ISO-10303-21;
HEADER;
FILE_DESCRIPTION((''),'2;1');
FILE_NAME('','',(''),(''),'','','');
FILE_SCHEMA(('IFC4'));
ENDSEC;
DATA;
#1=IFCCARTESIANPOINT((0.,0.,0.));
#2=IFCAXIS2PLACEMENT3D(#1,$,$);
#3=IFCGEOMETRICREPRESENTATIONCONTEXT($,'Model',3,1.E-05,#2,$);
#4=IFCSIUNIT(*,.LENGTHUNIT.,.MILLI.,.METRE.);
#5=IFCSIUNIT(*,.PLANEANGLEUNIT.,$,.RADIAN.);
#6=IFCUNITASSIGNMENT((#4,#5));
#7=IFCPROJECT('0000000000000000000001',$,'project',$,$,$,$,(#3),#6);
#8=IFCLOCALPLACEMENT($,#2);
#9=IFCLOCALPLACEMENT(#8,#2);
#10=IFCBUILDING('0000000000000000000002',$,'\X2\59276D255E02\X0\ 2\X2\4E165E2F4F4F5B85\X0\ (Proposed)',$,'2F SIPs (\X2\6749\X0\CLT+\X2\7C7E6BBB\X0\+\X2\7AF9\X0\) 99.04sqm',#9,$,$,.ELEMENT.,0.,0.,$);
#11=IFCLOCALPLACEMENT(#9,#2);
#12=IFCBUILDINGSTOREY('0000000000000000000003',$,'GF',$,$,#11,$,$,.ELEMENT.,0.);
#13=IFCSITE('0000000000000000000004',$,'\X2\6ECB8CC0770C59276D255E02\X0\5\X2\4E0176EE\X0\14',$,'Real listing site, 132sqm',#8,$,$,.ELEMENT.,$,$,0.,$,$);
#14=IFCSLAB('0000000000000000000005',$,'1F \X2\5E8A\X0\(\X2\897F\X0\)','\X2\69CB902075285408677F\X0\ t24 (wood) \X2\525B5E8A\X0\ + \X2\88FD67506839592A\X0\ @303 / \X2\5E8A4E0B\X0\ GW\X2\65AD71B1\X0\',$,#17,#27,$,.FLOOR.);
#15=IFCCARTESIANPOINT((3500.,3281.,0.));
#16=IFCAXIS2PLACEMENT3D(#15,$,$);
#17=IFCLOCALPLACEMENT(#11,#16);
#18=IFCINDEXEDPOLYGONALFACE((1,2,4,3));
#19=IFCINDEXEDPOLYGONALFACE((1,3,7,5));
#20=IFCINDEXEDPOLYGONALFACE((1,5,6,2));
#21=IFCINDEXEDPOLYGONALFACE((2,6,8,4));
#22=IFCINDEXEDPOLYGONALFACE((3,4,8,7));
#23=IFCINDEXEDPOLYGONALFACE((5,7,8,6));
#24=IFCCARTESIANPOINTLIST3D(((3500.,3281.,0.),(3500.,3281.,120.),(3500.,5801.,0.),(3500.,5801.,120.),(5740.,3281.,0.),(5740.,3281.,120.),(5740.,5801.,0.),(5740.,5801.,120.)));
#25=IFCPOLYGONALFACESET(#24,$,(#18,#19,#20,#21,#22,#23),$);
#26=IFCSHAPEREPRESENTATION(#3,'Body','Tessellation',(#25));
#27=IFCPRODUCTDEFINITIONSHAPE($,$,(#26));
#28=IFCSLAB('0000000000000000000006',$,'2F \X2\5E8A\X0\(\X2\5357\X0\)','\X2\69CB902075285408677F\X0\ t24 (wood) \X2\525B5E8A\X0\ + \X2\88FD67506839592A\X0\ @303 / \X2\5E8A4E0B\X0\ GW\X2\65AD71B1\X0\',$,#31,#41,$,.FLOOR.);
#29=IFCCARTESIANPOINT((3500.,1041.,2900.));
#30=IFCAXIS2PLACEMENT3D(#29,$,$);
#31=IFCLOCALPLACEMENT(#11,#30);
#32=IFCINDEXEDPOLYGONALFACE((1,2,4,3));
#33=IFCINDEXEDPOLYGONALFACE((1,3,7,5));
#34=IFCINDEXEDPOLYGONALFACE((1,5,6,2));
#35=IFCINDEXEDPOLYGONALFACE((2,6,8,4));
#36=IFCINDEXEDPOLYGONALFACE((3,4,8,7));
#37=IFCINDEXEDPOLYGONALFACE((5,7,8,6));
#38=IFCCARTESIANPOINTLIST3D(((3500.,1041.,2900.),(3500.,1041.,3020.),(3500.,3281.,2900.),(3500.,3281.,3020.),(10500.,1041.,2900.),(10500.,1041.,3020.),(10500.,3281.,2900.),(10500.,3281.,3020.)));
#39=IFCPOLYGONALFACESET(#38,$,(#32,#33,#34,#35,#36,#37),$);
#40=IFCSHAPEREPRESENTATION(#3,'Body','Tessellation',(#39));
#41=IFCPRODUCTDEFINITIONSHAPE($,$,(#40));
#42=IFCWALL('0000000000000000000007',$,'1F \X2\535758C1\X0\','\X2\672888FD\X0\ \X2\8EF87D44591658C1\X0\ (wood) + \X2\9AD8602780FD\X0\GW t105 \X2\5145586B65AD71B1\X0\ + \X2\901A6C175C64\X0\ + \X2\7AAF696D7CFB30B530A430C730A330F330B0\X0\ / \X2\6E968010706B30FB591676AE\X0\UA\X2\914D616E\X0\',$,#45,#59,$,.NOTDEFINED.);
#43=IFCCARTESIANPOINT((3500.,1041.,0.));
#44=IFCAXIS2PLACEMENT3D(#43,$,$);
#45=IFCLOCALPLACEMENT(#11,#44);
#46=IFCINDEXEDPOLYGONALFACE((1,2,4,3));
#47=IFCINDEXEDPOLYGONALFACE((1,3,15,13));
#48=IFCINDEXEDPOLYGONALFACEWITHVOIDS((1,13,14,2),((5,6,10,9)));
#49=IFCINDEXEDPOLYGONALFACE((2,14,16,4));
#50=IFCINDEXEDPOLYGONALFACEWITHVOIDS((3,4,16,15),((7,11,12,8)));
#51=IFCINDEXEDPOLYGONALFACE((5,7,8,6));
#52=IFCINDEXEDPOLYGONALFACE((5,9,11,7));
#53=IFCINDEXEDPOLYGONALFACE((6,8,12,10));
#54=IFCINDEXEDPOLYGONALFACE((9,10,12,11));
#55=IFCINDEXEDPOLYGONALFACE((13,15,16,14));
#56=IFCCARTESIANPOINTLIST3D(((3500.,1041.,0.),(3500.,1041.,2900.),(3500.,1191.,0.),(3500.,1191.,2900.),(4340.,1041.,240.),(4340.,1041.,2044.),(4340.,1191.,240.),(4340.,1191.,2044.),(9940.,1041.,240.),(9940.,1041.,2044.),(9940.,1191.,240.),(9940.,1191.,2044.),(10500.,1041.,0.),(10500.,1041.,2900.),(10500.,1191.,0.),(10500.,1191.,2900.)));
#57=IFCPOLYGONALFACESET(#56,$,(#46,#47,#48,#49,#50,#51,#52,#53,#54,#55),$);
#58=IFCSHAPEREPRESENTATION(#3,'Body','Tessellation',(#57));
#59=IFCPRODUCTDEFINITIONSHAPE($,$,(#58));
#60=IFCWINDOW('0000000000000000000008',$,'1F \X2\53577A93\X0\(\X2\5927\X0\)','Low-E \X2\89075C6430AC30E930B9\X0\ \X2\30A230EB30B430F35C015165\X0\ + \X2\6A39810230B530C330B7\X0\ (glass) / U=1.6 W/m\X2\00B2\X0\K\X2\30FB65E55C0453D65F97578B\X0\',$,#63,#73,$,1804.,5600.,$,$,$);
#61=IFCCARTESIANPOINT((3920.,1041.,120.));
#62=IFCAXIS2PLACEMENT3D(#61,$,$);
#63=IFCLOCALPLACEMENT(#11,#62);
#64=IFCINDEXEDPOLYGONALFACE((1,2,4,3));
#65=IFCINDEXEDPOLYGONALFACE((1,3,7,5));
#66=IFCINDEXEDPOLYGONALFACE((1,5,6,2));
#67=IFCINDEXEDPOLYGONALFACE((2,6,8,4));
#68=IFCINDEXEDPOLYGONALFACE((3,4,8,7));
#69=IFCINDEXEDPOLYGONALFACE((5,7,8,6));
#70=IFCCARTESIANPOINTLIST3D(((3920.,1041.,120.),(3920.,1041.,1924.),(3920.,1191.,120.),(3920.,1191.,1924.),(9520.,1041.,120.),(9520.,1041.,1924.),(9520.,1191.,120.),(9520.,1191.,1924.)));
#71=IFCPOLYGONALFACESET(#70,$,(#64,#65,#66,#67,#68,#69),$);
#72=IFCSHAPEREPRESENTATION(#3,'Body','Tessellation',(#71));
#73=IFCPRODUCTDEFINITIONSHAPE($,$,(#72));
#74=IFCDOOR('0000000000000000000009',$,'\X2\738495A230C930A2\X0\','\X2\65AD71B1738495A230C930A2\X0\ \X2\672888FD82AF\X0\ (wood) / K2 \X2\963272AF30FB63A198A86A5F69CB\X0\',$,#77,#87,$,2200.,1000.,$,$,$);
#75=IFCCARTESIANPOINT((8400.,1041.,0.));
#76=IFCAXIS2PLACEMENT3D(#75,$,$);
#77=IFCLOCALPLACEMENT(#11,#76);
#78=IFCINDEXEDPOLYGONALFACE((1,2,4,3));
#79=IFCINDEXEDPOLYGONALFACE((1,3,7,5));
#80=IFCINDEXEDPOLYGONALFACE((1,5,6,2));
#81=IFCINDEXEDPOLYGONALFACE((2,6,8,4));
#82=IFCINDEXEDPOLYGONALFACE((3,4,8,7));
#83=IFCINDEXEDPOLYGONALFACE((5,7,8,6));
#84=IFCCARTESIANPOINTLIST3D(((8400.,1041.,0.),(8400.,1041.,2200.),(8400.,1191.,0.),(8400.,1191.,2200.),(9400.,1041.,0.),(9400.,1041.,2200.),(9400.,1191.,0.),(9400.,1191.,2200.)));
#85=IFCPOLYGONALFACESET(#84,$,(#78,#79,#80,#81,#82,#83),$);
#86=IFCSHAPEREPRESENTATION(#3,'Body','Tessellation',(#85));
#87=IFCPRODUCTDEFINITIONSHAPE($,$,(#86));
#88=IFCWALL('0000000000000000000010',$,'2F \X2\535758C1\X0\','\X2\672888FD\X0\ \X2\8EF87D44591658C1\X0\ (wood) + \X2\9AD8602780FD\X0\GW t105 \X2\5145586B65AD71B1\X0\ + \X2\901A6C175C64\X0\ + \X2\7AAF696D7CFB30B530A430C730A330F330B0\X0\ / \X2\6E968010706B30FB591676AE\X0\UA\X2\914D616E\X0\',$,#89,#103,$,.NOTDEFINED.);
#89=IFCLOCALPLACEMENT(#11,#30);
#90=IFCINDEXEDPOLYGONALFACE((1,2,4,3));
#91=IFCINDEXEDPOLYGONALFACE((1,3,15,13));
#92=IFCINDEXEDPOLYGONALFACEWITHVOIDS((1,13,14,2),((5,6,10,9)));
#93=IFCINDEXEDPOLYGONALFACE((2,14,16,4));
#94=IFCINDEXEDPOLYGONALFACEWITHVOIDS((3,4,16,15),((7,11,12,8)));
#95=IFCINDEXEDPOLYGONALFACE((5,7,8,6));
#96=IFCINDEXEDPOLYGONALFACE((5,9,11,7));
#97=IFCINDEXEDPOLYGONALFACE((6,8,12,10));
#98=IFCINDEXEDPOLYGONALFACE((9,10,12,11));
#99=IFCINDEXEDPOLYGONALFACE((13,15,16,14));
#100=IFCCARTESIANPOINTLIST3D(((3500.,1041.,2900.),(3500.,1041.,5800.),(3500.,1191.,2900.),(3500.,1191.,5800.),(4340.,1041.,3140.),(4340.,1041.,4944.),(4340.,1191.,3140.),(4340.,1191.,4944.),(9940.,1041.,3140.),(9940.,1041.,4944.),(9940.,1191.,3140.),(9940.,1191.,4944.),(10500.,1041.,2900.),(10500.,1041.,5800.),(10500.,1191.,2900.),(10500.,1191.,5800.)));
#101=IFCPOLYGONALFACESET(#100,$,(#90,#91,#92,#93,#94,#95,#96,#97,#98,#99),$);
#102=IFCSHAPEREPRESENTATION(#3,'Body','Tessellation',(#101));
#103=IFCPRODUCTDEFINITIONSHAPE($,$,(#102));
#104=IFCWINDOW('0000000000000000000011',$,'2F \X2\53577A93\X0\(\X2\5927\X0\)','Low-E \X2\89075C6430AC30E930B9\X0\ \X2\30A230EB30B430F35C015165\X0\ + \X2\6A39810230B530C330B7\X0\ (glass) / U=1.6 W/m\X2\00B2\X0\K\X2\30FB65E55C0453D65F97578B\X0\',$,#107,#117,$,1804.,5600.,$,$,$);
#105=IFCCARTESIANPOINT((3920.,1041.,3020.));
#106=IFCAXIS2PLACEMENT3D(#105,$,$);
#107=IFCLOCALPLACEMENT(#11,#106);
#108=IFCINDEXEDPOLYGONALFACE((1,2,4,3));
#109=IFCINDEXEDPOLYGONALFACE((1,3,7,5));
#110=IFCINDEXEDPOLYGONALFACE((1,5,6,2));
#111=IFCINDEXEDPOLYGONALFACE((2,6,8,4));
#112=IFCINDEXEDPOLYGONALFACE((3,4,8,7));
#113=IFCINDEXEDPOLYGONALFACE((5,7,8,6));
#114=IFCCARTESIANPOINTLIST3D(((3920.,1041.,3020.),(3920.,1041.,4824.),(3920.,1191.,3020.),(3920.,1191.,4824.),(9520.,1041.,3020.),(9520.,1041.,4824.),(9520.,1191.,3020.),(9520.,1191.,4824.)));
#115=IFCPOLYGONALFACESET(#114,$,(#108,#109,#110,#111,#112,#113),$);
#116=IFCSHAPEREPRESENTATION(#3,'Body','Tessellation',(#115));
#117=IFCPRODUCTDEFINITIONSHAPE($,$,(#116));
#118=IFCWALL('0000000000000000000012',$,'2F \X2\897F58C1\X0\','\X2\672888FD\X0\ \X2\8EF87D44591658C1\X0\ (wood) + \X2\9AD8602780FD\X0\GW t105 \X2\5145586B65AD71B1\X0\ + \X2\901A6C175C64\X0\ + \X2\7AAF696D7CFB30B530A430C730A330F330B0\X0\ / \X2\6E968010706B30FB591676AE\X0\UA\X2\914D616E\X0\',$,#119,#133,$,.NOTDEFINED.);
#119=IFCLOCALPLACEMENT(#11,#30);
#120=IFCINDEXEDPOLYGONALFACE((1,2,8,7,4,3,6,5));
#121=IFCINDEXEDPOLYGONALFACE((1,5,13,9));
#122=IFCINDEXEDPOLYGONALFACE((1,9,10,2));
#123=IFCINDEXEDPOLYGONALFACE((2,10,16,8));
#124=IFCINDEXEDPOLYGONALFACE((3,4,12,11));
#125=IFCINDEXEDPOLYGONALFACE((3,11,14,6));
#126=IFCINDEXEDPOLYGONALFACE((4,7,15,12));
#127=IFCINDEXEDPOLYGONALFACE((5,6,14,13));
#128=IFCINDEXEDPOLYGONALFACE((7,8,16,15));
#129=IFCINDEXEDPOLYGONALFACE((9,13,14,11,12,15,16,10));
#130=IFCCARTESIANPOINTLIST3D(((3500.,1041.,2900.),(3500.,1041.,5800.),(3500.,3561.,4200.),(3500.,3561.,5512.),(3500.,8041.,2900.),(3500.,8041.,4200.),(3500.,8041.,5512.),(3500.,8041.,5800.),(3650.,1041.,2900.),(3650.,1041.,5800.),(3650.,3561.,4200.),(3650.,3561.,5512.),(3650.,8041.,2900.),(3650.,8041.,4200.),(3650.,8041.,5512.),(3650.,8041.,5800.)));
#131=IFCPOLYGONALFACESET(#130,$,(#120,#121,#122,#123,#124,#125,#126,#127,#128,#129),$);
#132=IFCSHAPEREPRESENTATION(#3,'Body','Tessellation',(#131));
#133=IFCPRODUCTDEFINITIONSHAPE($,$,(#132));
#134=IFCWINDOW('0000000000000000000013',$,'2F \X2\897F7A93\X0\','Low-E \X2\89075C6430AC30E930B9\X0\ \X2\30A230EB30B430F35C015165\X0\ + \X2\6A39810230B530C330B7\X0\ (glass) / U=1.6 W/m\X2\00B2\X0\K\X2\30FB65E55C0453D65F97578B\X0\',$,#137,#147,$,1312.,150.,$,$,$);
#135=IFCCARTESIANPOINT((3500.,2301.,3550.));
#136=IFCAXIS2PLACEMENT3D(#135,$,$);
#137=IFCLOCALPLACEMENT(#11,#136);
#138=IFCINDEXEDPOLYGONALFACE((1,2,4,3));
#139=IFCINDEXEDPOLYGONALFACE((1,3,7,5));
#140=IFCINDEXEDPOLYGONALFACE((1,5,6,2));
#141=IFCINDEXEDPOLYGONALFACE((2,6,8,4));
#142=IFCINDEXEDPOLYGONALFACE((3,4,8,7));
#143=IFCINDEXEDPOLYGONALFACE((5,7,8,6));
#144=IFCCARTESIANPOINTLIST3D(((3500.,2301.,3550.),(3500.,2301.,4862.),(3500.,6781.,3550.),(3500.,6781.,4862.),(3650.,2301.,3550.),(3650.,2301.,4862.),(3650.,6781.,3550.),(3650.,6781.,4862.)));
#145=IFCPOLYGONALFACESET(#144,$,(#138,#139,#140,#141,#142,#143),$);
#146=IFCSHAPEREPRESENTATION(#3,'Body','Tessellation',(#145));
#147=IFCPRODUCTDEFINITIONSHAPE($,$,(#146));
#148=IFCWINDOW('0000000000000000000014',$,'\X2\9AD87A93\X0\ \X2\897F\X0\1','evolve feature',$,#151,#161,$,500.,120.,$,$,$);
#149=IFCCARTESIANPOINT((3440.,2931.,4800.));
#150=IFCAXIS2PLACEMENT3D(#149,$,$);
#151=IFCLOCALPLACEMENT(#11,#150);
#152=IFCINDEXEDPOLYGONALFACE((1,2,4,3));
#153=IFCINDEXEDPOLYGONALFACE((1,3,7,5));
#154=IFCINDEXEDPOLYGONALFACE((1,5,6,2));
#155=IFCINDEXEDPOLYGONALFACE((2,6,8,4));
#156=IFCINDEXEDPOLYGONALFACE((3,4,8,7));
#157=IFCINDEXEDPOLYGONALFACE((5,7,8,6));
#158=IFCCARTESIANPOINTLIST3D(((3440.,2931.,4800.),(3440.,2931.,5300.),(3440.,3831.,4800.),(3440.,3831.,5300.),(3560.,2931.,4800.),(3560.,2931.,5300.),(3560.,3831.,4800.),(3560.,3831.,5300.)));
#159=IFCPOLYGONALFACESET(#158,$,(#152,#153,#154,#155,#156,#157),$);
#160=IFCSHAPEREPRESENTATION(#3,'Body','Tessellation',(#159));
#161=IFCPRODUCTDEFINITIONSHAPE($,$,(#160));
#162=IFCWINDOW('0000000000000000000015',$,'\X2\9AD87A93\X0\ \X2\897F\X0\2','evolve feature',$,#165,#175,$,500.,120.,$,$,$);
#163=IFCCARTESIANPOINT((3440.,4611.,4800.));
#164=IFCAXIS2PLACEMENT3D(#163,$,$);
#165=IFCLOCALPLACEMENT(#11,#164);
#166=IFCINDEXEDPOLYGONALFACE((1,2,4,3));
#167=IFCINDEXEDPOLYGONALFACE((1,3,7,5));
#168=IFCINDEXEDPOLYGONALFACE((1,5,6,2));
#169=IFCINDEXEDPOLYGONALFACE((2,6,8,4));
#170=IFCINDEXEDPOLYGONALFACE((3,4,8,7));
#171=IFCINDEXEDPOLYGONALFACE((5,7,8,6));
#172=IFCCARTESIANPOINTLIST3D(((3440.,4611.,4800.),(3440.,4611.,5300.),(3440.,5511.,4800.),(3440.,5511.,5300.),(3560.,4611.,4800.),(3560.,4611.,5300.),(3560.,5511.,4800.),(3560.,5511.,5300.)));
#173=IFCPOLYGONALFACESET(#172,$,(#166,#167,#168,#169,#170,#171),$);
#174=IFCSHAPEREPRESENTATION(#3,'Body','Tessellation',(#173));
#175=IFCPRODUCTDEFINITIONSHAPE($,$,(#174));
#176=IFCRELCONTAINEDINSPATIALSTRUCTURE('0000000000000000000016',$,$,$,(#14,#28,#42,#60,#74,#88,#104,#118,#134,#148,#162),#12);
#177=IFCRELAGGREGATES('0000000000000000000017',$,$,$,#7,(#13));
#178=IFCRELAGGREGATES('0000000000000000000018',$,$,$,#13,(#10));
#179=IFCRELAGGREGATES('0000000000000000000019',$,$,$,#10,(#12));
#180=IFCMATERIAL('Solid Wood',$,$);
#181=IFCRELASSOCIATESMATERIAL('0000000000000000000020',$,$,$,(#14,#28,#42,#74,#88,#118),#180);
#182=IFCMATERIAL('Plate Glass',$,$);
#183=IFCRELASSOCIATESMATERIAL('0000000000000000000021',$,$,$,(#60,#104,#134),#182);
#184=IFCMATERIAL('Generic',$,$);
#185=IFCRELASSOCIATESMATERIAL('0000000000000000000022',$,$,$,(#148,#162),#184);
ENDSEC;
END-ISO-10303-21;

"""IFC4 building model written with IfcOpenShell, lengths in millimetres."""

from ifc_helpers import new_model, si_unit, frame, frame_2d, origin, place, context, project, spatial, rectangle, extrude, material, element, fill, save


model = new_model("IFC4")

# Units and contexts
model_context = context("Model", 3, precision=1e-05, world=origin())
ifc_project = project(units=[si_unit("LENGTHUNIT", "METRE", prefix="MILLI"), si_unit("PLANEANGLEUNIT", "RADIAN")], contexts=[model_context])

# Site, building, storey
site_placement = place(None, origin())
site = spatial("IfcSite", under=ifc_project, at=site_placement, Name="滋賀県大津市5丁目14", ObjectType="Real listing site, 132sqm", CompositionType="ELEMENT", RefElevation=0.0)
building_placement = place(site_placement, origin())
building = spatial("IfcBuilding", under=site, at=building_placement, Name="大津市 2世帯住宅 (Proposed)", ObjectType="2F SIPs (杉CLT+籾殻+竹) 99.04sqm", CompositionType="ELEMENT", ElevationOfRefHeight=0.0, ElevationOfTerrain=0.0)
storey_placement = place(building_placement, origin())
storey = spatial("IfcBuildingStorey", under=building, at=storey_placement, Name="GF", CompositionType="ELEMENT", Elevation=0.0)

# Slabs
ifc_material_1 = material(Name="Solid Wood")
slab_1_placement = place(storey_placement, frame((3500.0, 3281.0, 0.0)))
element("IfcSlab", 1, at=slab_1_placement, inside=storey, material=ifc_material_1, Name="1F 床(西)", Description="構造用合板 t24 (wood) 剛床 + 製材根太 @303 / 床下 GW断熱", PredefinedType="FLOOR", context=model_context, shape_type="SweptSolid", body=[
    extrude(rectangle(XDim=2240.0, YDim=2520.0, at=frame_2d((1120.0, 1260.0))), frame((3500.0, 3281.0, 0.0)), (0.0, 0.0, 1.0), 120.0),
])
slab_2_placement = place(storey_placement, frame((3500.0, 1041.0, 2900.0)))
element("IfcSlab", 2, at=slab_2_placement, inside=storey, material=ifc_material_1, Name="2F 床(南)", Description="構造用合板 t24 (wood) 剛床 + 製材根太 @303 / 床下 GW断熱", PredefinedType="FLOOR", context=model_context, shape_type="SweptSolid", body=[
    extrude(rectangle(XDim=7000.0, YDim=2240.0, at=frame_2d((3500.0, 1120.0))), frame((3500.0, 1041.0, 2900.0)), (0.0, 0.0, 1.0), 120.0),
])
ifc_material_2 = material(Name="Generic")

# Wall, openings, window, door
wall_1_placement = place(storey_placement, frame((3500.0, 1041.0, 0.0)))
wall_1 = element("IfcWall", 3, at=wall_1_placement, inside=storey, material=ifc_material_1, Name="1F 南壁", Description="木製 軸組外壁 (wood) + 高性能GW t105 充填断熱 + 通気層 + 窯業系サイディング / 準耐火・外皮UA配慮", PredefinedType="NOTDEFINED", context=model_context, shape_type="SweptSolid", body=[
    extrude(rectangle(XDim=7000.0, YDim=150.0, at=frame_2d((3500.0, 75.0))), frame((3500.0, 1041.0, 0.0)), (0.0, 0.0, 1.0), 2900.0),
])
opening_1_placement = place(storey_placement, frame((3920.0, 1041.0, 120.0)))
opening_1 = element("IfcOpeningElement", 4, at=opening_1_placement, cuts=wall_1, PredefinedType="NOTDEFINED", context=model_context, shape_type="SweptSolid", body=[
    extrude(rectangle(XDim=5600.0, YDim=150.0, at=frame_2d((2800.0, 75.0))), frame((3920.0, 1041.0, 120.0)), (0.0, 0.0, 1.0), 1804.0),
])
opening_2_placement = place(storey_placement, frame((8400.0, 1041.0, 0.0)))
opening_2 = element("IfcOpeningElement", 5, at=opening_2_placement, cuts=wall_1, PredefinedType="NOTDEFINED", context=model_context, shape_type="SweptSolid", body=[
    extrude(rectangle(XDim=1000.0, YDim=150.0, at=frame_2d((500.0, 75.0))), frame((8400.0, 1041.0, 0.0)), (0.0, 0.0, 1.0), 2200.0),
])
ifc_material_3 = material(Name="Plate Glass")
window_1_placement = place(storey_placement, frame((3920.0, 1041.0, 120.0)))
window_1 = element("IfcWindow", 6, at=window_1_placement, inside=storey, material=ifc_material_3, Name="1F 南窓(大)", Description="Low-E 複層ガラス アルゴン封入 + 樹脂サッシ (glass) / U=1.6 W/m²K・日射取得型", OverallHeight=1804.0, OverallWidth=5600.0, context=model_context, shape_type="SweptSolid", body=[
    extrude(rectangle(XDim=5600.0, YDim=150.0, at=frame_2d((2800.0, 75.0))), frame((3920.0, 1041.0, 120.0)), (0.0, 0.0, 1.0), 1804.0),
])
fill(opening_1, window_1)
door_placement = place(storey_placement, frame((8400.0, 1041.0, 0.0)))
door = element("IfcDoor", 7, at=door_placement, inside=storey, material=ifc_material_1, Name="玄関ドア", Description="断熱玄関ドア 木製芯 (wood) / K2 防犯・採風機構", OverallHeight=2200.0, OverallWidth=1000.0, context=model_context, shape_type="SweptSolid", body=[
    extrude(rectangle(XDim=1000.0, YDim=150.0, at=frame_2d((500.0, 75.0))), frame((8400.0, 1041.0, 0.0)), (0.0, 0.0, 1.0), 2200.0),
])
fill(opening_2, door)

# Wall, opening, window
wall_2_placement = place(storey_placement, frame((3500.0, 1041.0, 2900.0)))
wall_2 = element("IfcWall", 8, at=wall_2_placement, inside=storey, material=ifc_material_1, Name="2F 南壁", Description="木製 軸組外壁 (wood) + 高性能GW t105 充填断熱 + 通気層 + 窯業系サイディング / 準耐火・外皮UA配慮", PredefinedType="NOTDEFINED", context=model_context, shape_type="SweptSolid", body=[
    extrude(rectangle(XDim=7000.0, YDim=150.0, at=frame_2d((3500.0, 75.0))), frame((3500.0, 1041.0, 2900.0)), (0.0, 0.0, 1.0), 2900.0),
])
opening_3_placement = place(storey_placement, frame((3920.0, 1041.0, 3020.0)))
opening_3 = element("IfcOpeningElement", 9, at=opening_3_placement, cuts=wall_2, PredefinedType="NOTDEFINED", context=model_context, shape_type="SweptSolid", body=[
    extrude(rectangle(XDim=5600.0, YDim=150.0, at=frame_2d((2800.0, 75.0))), frame((3920.0, 1041.0, 3020.0)), (0.0, 0.0, 1.0), 1804.0),
])
window_2_placement = place(storey_placement, frame((3920.0, 1041.0, 3020.0)))
window_2 = element("IfcWindow", 10, at=window_2_placement, inside=storey, material=ifc_material_3, Name="2F 南窓(大)", Description="Low-E 複層ガラス アルゴン封入 + 樹脂サッシ (glass) / U=1.6 W/m²K・日射取得型", OverallHeight=1804.0, OverallWidth=5600.0, context=model_context, shape_type="SweptSolid", body=[
    extrude(rectangle(XDim=5600.0, YDim=150.0, at=frame_2d((2800.0, 75.0))), frame((3920.0, 1041.0, 3020.0)), (0.0, 0.0, 1.0), 1804.0),
])
fill(opening_3, window_2)

# Wall, openings, windows
wall_3_placement = place(storey_placement, frame((3500.0, 1041.0, 2900.0)))
wall_3 = element("IfcWall", 11, at=wall_3_placement, inside=storey, material=ifc_material_1, Name="2F 西壁", Description="木製 軸組外壁 (wood) + 高性能GW t105 充填断熱 + 通気層 + 窯業系サイディング / 準耐火・外皮UA配慮", PredefinedType="NOTDEFINED", context=model_context, shape_type="SweptSolid", body=[
    extrude(rectangle(XDim=150.0, YDim=7000.0, at=frame_2d((75.0, 3500.0))), frame((3500.0, 1041.0, 2900.0)), (0.0, 0.0, 1.0), 2900.0),
])
opening_4_placement = place(storey_placement, frame((3500.0, 2301.0, 3550.0)))
opening_4 = element("IfcOpeningElement", 12, at=opening_4_placement, cuts=wall_3, PredefinedType="NOTDEFINED", context=model_context, shape_type="SweptSolid", body=[
    extrude(rectangle(XDim=150.0, YDim=4480.0, at=frame_2d((75.0, 2240.0))), frame((3500.0, 2301.0, 3550.0)), (0.0, 0.0, 1.0), 1312.0),
])
opening_5_placement = place(storey_placement, frame((3440.0, 2931.0, 4800.0)))
opening_5 = element("IfcOpeningElement", 13, at=opening_5_placement, cuts=wall_3, PredefinedType="NOTDEFINED", context=model_context, shape_type="SweptSolid", body=[
    extrude(rectangle(XDim=120.0, YDim=900.0, at=frame_2d((60.0, 450.0))), frame((3440.0, 2931.0, 4800.0)), (0.0, 0.0, 1.0), 500.0),
])
opening_6_placement = place(storey_placement, frame((3440.0, 4611.0, 4800.0)))
opening_6 = element("IfcOpeningElement", 14, at=opening_6_placement, cuts=wall_3, PredefinedType="NOTDEFINED", context=model_context, shape_type="SweptSolid", body=[
    extrude(rectangle(XDim=120.0, YDim=900.0, at=frame_2d((60.0, 450.0))), frame((3440.0, 4611.0, 4800.0)), (0.0, 0.0, 1.0), 500.0),
])
window_3_placement = place(storey_placement, frame((3500.0, 2301.0, 3550.0)))
window_3 = element("IfcWindow", 15, at=window_3_placement, inside=storey, material=ifc_material_3, Name="2F 西窓", Description="Low-E 複層ガラス アルゴン封入 + 樹脂サッシ (glass) / U=1.6 W/m²K・日射取得型", OverallHeight=1312.0, OverallWidth=150.0, context=model_context, shape_type="SweptSolid", body=[
    extrude(rectangle(XDim=150.0, YDim=4480.0, at=frame_2d((75.0, 2240.0))), frame((3500.0, 2301.0, 3550.0)), (0.0, 0.0, 1.0), 1312.0),
])
fill(opening_4, window_3)
window_4_placement = place(storey_placement, frame((3440.0, 2931.0, 4800.0)))
window_4 = element("IfcWindow", 16, at=window_4_placement, inside=storey, material=ifc_material_2, Name="高窓 西1", Description="evolve feature", OverallHeight=500.0, OverallWidth=120.0, context=model_context, shape_type="SweptSolid", body=[
    extrude(rectangle(XDim=120.0, YDim=900.0, at=frame_2d((60.0, 450.0))), frame((3440.0, 2931.0, 4800.0)), (0.0, 0.0, 1.0), 500.0),
])
fill(opening_5, window_4)
window_5_placement = place(storey_placement, frame((3440.0, 4611.0, 4800.0)))
window_5 = element("IfcWindow", 17, at=window_5_placement, inside=storey, material=ifc_material_2, Name="高窓 西2", Description="evolve feature", OverallHeight=500.0, OverallWidth=120.0, context=model_context, shape_type="SweptSolid", body=[
    extrude(rectangle(XDim=120.0, YDim=900.0, at=frame_2d((60.0, 450.0))), frame((3440.0, 4611.0, 4800.0)), (0.0, 0.0, 1.0), 500.0),
])
fill(opening_6, window_5)

save(model, "model.ifc")
